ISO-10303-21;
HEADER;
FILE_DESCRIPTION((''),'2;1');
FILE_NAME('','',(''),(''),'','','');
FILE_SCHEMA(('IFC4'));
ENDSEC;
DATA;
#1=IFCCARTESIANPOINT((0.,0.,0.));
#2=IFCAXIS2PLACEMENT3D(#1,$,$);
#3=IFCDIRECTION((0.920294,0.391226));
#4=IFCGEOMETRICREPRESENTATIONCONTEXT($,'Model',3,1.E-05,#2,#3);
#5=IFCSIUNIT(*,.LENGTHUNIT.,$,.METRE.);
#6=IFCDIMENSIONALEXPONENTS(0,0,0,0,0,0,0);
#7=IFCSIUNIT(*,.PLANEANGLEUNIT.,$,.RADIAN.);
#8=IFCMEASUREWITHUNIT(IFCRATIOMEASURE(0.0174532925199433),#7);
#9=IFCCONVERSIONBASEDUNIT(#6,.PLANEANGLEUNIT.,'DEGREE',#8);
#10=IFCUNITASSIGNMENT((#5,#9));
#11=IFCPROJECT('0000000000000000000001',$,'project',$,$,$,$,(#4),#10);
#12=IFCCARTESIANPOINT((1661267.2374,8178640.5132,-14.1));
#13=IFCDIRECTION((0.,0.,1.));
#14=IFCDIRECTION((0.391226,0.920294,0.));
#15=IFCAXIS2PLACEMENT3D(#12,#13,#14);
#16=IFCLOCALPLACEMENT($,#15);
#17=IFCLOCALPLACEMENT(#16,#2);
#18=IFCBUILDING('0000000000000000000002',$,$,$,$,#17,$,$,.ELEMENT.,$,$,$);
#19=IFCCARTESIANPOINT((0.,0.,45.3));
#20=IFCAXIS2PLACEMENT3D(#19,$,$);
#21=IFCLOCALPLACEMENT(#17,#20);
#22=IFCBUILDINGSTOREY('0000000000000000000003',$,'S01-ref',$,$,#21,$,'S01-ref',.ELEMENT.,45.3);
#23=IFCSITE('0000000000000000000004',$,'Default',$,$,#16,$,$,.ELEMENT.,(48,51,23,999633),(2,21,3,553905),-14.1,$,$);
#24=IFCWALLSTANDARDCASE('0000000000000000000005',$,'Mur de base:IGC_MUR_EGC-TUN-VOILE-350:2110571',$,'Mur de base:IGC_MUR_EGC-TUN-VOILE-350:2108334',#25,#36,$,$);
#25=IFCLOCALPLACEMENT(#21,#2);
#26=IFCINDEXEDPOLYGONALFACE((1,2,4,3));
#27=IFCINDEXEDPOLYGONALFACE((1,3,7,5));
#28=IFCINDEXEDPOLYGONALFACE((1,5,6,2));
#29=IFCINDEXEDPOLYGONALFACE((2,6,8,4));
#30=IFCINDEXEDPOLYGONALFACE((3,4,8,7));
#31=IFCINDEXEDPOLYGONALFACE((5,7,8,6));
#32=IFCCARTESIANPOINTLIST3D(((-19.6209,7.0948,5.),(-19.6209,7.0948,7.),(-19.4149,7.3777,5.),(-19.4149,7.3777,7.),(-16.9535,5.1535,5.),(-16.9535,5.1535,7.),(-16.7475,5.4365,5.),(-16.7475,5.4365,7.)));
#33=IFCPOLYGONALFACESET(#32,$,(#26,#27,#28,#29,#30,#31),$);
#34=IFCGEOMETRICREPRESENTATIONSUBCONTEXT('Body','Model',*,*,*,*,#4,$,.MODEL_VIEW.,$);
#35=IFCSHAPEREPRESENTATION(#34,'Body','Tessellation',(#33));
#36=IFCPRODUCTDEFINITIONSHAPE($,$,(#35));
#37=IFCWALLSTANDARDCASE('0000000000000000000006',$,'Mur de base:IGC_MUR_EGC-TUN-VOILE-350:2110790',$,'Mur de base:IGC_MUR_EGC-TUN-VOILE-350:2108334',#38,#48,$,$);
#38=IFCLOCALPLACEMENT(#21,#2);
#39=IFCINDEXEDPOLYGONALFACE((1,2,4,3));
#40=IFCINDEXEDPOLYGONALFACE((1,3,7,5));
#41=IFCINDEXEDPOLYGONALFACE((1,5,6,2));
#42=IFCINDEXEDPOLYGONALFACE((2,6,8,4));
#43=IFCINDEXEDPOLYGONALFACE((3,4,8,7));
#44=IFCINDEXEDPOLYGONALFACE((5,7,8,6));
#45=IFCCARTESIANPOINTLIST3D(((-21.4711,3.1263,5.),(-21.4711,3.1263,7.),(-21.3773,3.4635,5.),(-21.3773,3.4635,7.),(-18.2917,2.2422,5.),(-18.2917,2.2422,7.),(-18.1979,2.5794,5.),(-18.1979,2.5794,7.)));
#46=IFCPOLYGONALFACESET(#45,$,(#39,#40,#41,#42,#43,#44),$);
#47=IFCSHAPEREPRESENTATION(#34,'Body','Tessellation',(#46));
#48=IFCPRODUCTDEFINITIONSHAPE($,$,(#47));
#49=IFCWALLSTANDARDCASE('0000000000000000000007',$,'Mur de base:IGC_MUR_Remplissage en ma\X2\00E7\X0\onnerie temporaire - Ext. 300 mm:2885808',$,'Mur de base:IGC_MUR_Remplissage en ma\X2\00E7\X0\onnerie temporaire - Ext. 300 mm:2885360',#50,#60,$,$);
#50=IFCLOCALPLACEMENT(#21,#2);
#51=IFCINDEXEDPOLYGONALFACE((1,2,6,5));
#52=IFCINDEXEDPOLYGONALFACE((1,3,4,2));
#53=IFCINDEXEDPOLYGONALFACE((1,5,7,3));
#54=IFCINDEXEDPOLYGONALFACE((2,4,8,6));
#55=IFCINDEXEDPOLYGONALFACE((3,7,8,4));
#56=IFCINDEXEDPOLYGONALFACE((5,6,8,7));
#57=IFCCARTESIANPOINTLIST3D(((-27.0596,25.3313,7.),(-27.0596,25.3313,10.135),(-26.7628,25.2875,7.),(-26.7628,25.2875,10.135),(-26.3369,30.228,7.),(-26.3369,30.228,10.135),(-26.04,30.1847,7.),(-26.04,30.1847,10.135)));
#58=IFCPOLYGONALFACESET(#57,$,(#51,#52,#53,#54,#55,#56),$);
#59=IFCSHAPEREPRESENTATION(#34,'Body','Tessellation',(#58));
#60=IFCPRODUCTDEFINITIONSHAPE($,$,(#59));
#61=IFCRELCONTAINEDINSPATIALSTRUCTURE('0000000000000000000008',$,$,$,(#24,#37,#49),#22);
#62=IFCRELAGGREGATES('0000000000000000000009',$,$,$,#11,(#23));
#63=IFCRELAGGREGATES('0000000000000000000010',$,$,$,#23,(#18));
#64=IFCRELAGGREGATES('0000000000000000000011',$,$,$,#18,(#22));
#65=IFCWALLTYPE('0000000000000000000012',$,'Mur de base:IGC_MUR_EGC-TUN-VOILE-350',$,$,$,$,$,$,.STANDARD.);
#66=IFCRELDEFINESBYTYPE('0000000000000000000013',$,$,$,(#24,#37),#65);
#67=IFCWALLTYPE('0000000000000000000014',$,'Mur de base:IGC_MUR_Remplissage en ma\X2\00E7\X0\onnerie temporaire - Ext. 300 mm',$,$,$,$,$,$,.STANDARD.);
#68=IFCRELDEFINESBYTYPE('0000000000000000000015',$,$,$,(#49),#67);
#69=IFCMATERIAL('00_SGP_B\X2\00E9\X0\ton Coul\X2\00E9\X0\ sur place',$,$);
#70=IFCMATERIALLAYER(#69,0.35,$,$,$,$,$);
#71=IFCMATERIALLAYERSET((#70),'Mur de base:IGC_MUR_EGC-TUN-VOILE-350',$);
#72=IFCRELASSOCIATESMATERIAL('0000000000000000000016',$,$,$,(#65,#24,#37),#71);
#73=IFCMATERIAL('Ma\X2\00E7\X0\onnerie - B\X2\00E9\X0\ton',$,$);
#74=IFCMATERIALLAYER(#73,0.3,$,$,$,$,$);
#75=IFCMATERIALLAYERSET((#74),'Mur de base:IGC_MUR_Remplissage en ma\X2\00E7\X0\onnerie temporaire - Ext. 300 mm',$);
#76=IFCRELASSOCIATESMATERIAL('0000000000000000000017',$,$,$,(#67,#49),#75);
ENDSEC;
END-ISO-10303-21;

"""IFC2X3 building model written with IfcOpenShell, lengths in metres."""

from ifc_helpers import new_model, entity, si_unit, converted_unit, direction, frame, frame_2d, origin, place, context, subcontext, project, spatial, polyline, rectangle, outline, extrude, material, layer, layer_set, layer_usage, type_object, element, save


model = new_model("IFC2X3")

# Units and contexts
model_context = context("Model", 3, precision=1e-05, world=origin(), true_north=direction((0.920294, 0.391226)))
body_context = subcontext(model_context, "Body", "Model", "MODEL_VIEW")
ifc_project = project(units=[si_unit("LENGTHUNIT", "METRE"), converted_unit("PLANEANGLEUNIT", "DEGREE", entity("IfcRatioMeasure", 0.0174532925199433), si_unit("PLANEANGLEUNIT", "RADIAN"), dimensions=[0, 0, 0, 0, 0, 0, 0])], contexts=[model_context])

# Site, building, storey
site_placement = place(None, frame((1661267.2374, 8178640.5132, -14.1), z_axis=(0.0, 0.0, 1.0), x_axis=(0.391226, 0.920294, 0.0)))
site = spatial("IfcSite", under=ifc_project, at=site_placement, Name="Default", CompositionType="ELEMENT", RefLatitude=(48, 51, 23, 999633), RefLongitude=(2, 21, 3, 553905), RefElevation=-14.1)
building_placement = place(site_placement, origin())
building = spatial("IfcBuilding", under=site, at=building_placement, CompositionType="ELEMENT")
storey_placement = place(building_placement, frame((0.0, 0.0, 45.3)))
storey = spatial("IfcBuildingStorey", under=building, at=storey_placement, Name="S01-ref", LongName="S01-ref", CompositionType="ELEMENT", Elevation=45.3)

# Shared definitions
ifc_material_1 = material(Name="00_SGP_Béton Coulé sur place")

# Walls
ifc_layer_1 = layer(ifc_material_1, 0.35)
ifc_layer_set_1 = layer_set([ifc_layer_1], Name="Mur de base:IGC_MUR_EGC-TUN-VOILE-350")
wall_type_1 = type_object("IfcWallType", Name="Mur de base:IGC_MUR_EGC-TUN-VOILE-350", PredefinedType="STANDARD", material=ifc_layer_set_1)
ifc_layer_usage_1 = layer_usage(ifc_layer_set_1, "AXIS2", "POSITIVE", -0.175)
wall_1_placement = place(storey_placement, frame((-16.8505, 5.295, 5.0), z_axis=(0.0, 0.0, 1.0), x_axis=(-0.808541, 0.58844, 0.0)))
element("IfcWallStandardCase", 1, at=wall_1_placement, inside=storey, type_object=wall_type_1, material=ifc_layer_usage_1, Name="Mur de base:IGC_MUR_EGC-TUN-VOILE-350:2110571", ObjectType="Mur de base:IGC_MUR_EGC-TUN-VOILE-350:2108334", context=body_context, shape_type="SweptSolid", body=[
    extrude(rectangle(XDim=3.299, YDim=0.35, at=frame_2d((1.6495, 0.0), x_axis=(-1.0, 0.0))), origin(), (0.0, 0.0, 1.0), 2.0),
])
ifc_layer_usage_2 = layer_usage(ifc_layer_set_1, "AXIS2", "POSITIVE", -0.175)
wall_2_placement = place(storey_placement, frame((-18.2448, 2.4108, 5.0), z_axis=(0.0, 0.0, 1.0), x_axis=(-0.963446, 0.267903, 0.0)))
element("IfcWallStandardCase", 2, at=wall_2_placement, inside=storey, type_object=wall_type_1, material=ifc_layer_usage_2, Name="Mur de base:IGC_MUR_EGC-TUN-VOILE-350:2110790", ObjectType="Mur de base:IGC_MUR_EGC-TUN-VOILE-350:2108334", context=body_context, shape_type="SweptSolid", body=[
    extrude(rectangle(XDim=3.3, YDim=0.35, at=frame_2d((1.65, 0.0), x_axis=(-1.0, 0.0))), origin(), (0.0, 0.0, 1.0), 2.0),
])
ifc_material_2 = material(Name="Maçonnerie - Béton")
ifc_layer_2 = layer(ifc_material_2, 0.3)
ifc_layer_set_2 = layer_set([ifc_layer_2], Name="Mur de base:IGC_MUR_Remplissage en maçonnerie temporaire - Ext. 300 mm")
ifc_layer_usage_3 = layer_usage(ifc_layer_set_2, "AXIS2", "NEGATIVE", 0.15)
wall_type_2 = type_object("IfcWallType", Name="Mur de base:IGC_MUR_Remplissage en maçonnerie temporaire - Ext. 300 mm", PredefinedType="STANDARD", material=ifc_layer_set_2)
wall_3_placement = place(storey_placement, frame((-26.9112, 25.3094, 7.0), z_axis=(0.0, 0.0, 1.0), x_axis=(0.146005, 0.989284, 0.0)))
element("IfcWallStandardCase", 3, at=wall_3_placement, inside=storey, type_object=wall_type_2, material=ifc_layer_usage_3, Name="Mur de base:IGC_MUR_Remplissage en maçonnerie temporaire - Ext. 300 mm:2885808", ObjectType="Mur de base:IGC_MUR_Remplissage en maçonnerie temporaire - Ext. 300 mm:2885360", context=body_context, shape_type="SweptSolid", body=[
    extrude(outline(polyline([(4.9502, -0.15), (4.9498, 0.15), (0.0, 0.15), (0.0, -0.15), (4.9502, -0.15)])), origin(), (0.0, 0.0, 1.0), 3.135),
])

save(model, "model.ifc")
